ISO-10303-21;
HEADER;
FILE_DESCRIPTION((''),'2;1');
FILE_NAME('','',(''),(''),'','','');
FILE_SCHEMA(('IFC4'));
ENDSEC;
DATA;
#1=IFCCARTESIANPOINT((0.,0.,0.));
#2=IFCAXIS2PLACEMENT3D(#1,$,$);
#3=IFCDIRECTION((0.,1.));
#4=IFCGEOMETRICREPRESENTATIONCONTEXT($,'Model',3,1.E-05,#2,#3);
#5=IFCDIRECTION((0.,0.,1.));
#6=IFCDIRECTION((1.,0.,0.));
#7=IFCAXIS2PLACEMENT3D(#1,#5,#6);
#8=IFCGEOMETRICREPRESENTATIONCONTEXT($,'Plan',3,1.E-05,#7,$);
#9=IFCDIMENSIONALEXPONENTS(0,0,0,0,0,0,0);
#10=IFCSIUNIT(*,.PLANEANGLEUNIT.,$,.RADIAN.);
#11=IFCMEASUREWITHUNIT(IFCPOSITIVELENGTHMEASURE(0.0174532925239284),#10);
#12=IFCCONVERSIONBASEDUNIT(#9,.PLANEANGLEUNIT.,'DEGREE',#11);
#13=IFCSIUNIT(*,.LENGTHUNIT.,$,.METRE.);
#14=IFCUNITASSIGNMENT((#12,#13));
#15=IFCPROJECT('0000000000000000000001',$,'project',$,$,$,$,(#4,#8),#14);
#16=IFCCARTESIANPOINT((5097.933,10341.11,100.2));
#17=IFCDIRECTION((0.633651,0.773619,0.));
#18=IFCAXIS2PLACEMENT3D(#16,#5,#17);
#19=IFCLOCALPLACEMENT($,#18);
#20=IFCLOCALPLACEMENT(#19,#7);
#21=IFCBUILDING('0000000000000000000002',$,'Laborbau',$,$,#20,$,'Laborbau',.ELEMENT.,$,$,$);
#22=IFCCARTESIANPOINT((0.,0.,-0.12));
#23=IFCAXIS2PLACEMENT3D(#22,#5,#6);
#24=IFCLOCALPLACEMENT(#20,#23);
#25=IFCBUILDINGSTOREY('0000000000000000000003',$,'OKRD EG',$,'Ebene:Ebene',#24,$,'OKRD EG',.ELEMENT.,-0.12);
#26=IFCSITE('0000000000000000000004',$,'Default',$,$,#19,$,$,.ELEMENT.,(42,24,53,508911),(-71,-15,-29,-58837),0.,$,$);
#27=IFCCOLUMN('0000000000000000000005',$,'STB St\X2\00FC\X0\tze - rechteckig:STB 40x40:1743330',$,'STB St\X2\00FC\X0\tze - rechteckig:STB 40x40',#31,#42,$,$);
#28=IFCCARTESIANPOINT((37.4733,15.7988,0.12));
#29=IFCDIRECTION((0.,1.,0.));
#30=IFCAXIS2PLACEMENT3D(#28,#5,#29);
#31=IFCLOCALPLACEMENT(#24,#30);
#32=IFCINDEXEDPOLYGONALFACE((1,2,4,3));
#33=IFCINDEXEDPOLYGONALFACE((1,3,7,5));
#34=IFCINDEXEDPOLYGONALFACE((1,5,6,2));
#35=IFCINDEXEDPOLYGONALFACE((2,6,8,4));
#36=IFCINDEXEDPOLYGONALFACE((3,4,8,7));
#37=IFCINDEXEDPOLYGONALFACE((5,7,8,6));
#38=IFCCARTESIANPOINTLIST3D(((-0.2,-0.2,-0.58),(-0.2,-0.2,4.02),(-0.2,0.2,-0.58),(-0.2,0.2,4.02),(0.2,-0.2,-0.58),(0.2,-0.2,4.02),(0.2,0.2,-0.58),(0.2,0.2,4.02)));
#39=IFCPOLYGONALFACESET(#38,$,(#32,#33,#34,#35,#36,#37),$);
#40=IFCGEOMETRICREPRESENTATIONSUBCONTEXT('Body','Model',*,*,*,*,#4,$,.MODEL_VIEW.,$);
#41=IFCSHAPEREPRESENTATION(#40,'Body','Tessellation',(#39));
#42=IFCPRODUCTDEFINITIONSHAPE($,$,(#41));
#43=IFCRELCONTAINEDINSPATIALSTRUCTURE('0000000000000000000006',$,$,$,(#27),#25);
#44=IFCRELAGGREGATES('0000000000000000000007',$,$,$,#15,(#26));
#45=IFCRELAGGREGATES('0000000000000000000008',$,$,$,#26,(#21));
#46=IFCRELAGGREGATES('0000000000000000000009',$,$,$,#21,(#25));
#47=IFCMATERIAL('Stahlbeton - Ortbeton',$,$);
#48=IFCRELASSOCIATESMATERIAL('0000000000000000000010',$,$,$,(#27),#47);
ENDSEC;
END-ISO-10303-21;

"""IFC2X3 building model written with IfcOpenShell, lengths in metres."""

from ifc_helpers import new_model, entity, si_unit, converted_unit, direction, frame, origin, origin_with_axes, origin_2d_with_axis, place, context, subcontext, project, spatial, rectangle, extrude, source, transform, mapped, material, element, save


model = new_model("IFC2X3")

# Units and contexts
model_context = context("Model", 3, precision=1e-05, world=origin(), true_north=direction((0.0, 1.0)))
plan_context = context("Plan", 3, precision=1e-05, world=origin_with_axes())
body_context = subcontext(model_context, "Body", "Model", "MODEL_VIEW")
ifc_project = project(units=[converted_unit("PLANEANGLEUNIT", "DEGREE", entity("IfcPositiveLengthMeasure", 0.0174532925239284), si_unit("PLANEANGLEUNIT", "RADIAN"), dimensions=[0, 0, 0, 0, 0, 0, 0]), si_unit("LENGTHUNIT", "METRE")], contexts=[model_context, plan_context])

# Site, building, storey
site_placement = place(None, frame((5097.933, 10341.11, 100.2), z_axis=(0.0, 0.0, 1.0), x_axis=(0.633651, 0.773619, 0.0)))
site = spatial("IfcSite", under=ifc_project, at=site_placement, Name="Default", CompositionType="ELEMENT", RefLatitude=(42, 24, 53, 508911), RefLongitude=(-71, -15, -29, -58837), RefElevation=0.0)
building_placement = place(site_placement, origin_with_axes())
building = spatial("IfcBuilding", under=site, at=building_placement, Name="Laborbau", LongName="Laborbau", CompositionType="ELEMENT")
storey_placement = place(building_placement, frame((0.0, 0.0, -0.12), z_axis=(0.0, 0.0, 1.0), x_axis=(1.0, 0.0, 0.0)))
storey = spatial("IfcBuildingStorey", under=building, at=storey_placement, Name="OKRD EG", ObjectType="Ebene:Ebene", LongName="OKRD EG", CompositionType="ELEMENT", Elevation=-0.12)

# Column
ifc_material_1 = material(Name="Stahlbeton - Ortbeton")
shared_shape = source(origin(), body_context, "Body", "SweptSolid", [
    extrude(rectangle(XDim=0.4, YDim=0.4, at=origin_2d_with_axis()), frame((0.0, 0.0, -0.58), z_axis=(0.0, 0.0, 1.0), x_axis=(0.0, -1.0, 0.0)), (0.0, 0.0, 1.0), 4.6),
])
column_placement = place(storey_placement, frame((37.4733, 15.7988, 0.12), z_axis=(0.0, 0.0, 1.0), x_axis=(0.0, 1.0, 0.0)))
element("IfcColumn", 1, at=column_placement, inside=storey, material=ifc_material_1, Name="STB Stütze - rechteckig:STB 40x40:1743330", ObjectType="STB Stütze - rechteckig:STB 40x40", context=body_context, shape_type="MappedRepresentation", body=[
    mapped(shared_shape, transform((0.0, 0.0, 0.0), scale=1.0)),
])

save(model, "model.ifc")
